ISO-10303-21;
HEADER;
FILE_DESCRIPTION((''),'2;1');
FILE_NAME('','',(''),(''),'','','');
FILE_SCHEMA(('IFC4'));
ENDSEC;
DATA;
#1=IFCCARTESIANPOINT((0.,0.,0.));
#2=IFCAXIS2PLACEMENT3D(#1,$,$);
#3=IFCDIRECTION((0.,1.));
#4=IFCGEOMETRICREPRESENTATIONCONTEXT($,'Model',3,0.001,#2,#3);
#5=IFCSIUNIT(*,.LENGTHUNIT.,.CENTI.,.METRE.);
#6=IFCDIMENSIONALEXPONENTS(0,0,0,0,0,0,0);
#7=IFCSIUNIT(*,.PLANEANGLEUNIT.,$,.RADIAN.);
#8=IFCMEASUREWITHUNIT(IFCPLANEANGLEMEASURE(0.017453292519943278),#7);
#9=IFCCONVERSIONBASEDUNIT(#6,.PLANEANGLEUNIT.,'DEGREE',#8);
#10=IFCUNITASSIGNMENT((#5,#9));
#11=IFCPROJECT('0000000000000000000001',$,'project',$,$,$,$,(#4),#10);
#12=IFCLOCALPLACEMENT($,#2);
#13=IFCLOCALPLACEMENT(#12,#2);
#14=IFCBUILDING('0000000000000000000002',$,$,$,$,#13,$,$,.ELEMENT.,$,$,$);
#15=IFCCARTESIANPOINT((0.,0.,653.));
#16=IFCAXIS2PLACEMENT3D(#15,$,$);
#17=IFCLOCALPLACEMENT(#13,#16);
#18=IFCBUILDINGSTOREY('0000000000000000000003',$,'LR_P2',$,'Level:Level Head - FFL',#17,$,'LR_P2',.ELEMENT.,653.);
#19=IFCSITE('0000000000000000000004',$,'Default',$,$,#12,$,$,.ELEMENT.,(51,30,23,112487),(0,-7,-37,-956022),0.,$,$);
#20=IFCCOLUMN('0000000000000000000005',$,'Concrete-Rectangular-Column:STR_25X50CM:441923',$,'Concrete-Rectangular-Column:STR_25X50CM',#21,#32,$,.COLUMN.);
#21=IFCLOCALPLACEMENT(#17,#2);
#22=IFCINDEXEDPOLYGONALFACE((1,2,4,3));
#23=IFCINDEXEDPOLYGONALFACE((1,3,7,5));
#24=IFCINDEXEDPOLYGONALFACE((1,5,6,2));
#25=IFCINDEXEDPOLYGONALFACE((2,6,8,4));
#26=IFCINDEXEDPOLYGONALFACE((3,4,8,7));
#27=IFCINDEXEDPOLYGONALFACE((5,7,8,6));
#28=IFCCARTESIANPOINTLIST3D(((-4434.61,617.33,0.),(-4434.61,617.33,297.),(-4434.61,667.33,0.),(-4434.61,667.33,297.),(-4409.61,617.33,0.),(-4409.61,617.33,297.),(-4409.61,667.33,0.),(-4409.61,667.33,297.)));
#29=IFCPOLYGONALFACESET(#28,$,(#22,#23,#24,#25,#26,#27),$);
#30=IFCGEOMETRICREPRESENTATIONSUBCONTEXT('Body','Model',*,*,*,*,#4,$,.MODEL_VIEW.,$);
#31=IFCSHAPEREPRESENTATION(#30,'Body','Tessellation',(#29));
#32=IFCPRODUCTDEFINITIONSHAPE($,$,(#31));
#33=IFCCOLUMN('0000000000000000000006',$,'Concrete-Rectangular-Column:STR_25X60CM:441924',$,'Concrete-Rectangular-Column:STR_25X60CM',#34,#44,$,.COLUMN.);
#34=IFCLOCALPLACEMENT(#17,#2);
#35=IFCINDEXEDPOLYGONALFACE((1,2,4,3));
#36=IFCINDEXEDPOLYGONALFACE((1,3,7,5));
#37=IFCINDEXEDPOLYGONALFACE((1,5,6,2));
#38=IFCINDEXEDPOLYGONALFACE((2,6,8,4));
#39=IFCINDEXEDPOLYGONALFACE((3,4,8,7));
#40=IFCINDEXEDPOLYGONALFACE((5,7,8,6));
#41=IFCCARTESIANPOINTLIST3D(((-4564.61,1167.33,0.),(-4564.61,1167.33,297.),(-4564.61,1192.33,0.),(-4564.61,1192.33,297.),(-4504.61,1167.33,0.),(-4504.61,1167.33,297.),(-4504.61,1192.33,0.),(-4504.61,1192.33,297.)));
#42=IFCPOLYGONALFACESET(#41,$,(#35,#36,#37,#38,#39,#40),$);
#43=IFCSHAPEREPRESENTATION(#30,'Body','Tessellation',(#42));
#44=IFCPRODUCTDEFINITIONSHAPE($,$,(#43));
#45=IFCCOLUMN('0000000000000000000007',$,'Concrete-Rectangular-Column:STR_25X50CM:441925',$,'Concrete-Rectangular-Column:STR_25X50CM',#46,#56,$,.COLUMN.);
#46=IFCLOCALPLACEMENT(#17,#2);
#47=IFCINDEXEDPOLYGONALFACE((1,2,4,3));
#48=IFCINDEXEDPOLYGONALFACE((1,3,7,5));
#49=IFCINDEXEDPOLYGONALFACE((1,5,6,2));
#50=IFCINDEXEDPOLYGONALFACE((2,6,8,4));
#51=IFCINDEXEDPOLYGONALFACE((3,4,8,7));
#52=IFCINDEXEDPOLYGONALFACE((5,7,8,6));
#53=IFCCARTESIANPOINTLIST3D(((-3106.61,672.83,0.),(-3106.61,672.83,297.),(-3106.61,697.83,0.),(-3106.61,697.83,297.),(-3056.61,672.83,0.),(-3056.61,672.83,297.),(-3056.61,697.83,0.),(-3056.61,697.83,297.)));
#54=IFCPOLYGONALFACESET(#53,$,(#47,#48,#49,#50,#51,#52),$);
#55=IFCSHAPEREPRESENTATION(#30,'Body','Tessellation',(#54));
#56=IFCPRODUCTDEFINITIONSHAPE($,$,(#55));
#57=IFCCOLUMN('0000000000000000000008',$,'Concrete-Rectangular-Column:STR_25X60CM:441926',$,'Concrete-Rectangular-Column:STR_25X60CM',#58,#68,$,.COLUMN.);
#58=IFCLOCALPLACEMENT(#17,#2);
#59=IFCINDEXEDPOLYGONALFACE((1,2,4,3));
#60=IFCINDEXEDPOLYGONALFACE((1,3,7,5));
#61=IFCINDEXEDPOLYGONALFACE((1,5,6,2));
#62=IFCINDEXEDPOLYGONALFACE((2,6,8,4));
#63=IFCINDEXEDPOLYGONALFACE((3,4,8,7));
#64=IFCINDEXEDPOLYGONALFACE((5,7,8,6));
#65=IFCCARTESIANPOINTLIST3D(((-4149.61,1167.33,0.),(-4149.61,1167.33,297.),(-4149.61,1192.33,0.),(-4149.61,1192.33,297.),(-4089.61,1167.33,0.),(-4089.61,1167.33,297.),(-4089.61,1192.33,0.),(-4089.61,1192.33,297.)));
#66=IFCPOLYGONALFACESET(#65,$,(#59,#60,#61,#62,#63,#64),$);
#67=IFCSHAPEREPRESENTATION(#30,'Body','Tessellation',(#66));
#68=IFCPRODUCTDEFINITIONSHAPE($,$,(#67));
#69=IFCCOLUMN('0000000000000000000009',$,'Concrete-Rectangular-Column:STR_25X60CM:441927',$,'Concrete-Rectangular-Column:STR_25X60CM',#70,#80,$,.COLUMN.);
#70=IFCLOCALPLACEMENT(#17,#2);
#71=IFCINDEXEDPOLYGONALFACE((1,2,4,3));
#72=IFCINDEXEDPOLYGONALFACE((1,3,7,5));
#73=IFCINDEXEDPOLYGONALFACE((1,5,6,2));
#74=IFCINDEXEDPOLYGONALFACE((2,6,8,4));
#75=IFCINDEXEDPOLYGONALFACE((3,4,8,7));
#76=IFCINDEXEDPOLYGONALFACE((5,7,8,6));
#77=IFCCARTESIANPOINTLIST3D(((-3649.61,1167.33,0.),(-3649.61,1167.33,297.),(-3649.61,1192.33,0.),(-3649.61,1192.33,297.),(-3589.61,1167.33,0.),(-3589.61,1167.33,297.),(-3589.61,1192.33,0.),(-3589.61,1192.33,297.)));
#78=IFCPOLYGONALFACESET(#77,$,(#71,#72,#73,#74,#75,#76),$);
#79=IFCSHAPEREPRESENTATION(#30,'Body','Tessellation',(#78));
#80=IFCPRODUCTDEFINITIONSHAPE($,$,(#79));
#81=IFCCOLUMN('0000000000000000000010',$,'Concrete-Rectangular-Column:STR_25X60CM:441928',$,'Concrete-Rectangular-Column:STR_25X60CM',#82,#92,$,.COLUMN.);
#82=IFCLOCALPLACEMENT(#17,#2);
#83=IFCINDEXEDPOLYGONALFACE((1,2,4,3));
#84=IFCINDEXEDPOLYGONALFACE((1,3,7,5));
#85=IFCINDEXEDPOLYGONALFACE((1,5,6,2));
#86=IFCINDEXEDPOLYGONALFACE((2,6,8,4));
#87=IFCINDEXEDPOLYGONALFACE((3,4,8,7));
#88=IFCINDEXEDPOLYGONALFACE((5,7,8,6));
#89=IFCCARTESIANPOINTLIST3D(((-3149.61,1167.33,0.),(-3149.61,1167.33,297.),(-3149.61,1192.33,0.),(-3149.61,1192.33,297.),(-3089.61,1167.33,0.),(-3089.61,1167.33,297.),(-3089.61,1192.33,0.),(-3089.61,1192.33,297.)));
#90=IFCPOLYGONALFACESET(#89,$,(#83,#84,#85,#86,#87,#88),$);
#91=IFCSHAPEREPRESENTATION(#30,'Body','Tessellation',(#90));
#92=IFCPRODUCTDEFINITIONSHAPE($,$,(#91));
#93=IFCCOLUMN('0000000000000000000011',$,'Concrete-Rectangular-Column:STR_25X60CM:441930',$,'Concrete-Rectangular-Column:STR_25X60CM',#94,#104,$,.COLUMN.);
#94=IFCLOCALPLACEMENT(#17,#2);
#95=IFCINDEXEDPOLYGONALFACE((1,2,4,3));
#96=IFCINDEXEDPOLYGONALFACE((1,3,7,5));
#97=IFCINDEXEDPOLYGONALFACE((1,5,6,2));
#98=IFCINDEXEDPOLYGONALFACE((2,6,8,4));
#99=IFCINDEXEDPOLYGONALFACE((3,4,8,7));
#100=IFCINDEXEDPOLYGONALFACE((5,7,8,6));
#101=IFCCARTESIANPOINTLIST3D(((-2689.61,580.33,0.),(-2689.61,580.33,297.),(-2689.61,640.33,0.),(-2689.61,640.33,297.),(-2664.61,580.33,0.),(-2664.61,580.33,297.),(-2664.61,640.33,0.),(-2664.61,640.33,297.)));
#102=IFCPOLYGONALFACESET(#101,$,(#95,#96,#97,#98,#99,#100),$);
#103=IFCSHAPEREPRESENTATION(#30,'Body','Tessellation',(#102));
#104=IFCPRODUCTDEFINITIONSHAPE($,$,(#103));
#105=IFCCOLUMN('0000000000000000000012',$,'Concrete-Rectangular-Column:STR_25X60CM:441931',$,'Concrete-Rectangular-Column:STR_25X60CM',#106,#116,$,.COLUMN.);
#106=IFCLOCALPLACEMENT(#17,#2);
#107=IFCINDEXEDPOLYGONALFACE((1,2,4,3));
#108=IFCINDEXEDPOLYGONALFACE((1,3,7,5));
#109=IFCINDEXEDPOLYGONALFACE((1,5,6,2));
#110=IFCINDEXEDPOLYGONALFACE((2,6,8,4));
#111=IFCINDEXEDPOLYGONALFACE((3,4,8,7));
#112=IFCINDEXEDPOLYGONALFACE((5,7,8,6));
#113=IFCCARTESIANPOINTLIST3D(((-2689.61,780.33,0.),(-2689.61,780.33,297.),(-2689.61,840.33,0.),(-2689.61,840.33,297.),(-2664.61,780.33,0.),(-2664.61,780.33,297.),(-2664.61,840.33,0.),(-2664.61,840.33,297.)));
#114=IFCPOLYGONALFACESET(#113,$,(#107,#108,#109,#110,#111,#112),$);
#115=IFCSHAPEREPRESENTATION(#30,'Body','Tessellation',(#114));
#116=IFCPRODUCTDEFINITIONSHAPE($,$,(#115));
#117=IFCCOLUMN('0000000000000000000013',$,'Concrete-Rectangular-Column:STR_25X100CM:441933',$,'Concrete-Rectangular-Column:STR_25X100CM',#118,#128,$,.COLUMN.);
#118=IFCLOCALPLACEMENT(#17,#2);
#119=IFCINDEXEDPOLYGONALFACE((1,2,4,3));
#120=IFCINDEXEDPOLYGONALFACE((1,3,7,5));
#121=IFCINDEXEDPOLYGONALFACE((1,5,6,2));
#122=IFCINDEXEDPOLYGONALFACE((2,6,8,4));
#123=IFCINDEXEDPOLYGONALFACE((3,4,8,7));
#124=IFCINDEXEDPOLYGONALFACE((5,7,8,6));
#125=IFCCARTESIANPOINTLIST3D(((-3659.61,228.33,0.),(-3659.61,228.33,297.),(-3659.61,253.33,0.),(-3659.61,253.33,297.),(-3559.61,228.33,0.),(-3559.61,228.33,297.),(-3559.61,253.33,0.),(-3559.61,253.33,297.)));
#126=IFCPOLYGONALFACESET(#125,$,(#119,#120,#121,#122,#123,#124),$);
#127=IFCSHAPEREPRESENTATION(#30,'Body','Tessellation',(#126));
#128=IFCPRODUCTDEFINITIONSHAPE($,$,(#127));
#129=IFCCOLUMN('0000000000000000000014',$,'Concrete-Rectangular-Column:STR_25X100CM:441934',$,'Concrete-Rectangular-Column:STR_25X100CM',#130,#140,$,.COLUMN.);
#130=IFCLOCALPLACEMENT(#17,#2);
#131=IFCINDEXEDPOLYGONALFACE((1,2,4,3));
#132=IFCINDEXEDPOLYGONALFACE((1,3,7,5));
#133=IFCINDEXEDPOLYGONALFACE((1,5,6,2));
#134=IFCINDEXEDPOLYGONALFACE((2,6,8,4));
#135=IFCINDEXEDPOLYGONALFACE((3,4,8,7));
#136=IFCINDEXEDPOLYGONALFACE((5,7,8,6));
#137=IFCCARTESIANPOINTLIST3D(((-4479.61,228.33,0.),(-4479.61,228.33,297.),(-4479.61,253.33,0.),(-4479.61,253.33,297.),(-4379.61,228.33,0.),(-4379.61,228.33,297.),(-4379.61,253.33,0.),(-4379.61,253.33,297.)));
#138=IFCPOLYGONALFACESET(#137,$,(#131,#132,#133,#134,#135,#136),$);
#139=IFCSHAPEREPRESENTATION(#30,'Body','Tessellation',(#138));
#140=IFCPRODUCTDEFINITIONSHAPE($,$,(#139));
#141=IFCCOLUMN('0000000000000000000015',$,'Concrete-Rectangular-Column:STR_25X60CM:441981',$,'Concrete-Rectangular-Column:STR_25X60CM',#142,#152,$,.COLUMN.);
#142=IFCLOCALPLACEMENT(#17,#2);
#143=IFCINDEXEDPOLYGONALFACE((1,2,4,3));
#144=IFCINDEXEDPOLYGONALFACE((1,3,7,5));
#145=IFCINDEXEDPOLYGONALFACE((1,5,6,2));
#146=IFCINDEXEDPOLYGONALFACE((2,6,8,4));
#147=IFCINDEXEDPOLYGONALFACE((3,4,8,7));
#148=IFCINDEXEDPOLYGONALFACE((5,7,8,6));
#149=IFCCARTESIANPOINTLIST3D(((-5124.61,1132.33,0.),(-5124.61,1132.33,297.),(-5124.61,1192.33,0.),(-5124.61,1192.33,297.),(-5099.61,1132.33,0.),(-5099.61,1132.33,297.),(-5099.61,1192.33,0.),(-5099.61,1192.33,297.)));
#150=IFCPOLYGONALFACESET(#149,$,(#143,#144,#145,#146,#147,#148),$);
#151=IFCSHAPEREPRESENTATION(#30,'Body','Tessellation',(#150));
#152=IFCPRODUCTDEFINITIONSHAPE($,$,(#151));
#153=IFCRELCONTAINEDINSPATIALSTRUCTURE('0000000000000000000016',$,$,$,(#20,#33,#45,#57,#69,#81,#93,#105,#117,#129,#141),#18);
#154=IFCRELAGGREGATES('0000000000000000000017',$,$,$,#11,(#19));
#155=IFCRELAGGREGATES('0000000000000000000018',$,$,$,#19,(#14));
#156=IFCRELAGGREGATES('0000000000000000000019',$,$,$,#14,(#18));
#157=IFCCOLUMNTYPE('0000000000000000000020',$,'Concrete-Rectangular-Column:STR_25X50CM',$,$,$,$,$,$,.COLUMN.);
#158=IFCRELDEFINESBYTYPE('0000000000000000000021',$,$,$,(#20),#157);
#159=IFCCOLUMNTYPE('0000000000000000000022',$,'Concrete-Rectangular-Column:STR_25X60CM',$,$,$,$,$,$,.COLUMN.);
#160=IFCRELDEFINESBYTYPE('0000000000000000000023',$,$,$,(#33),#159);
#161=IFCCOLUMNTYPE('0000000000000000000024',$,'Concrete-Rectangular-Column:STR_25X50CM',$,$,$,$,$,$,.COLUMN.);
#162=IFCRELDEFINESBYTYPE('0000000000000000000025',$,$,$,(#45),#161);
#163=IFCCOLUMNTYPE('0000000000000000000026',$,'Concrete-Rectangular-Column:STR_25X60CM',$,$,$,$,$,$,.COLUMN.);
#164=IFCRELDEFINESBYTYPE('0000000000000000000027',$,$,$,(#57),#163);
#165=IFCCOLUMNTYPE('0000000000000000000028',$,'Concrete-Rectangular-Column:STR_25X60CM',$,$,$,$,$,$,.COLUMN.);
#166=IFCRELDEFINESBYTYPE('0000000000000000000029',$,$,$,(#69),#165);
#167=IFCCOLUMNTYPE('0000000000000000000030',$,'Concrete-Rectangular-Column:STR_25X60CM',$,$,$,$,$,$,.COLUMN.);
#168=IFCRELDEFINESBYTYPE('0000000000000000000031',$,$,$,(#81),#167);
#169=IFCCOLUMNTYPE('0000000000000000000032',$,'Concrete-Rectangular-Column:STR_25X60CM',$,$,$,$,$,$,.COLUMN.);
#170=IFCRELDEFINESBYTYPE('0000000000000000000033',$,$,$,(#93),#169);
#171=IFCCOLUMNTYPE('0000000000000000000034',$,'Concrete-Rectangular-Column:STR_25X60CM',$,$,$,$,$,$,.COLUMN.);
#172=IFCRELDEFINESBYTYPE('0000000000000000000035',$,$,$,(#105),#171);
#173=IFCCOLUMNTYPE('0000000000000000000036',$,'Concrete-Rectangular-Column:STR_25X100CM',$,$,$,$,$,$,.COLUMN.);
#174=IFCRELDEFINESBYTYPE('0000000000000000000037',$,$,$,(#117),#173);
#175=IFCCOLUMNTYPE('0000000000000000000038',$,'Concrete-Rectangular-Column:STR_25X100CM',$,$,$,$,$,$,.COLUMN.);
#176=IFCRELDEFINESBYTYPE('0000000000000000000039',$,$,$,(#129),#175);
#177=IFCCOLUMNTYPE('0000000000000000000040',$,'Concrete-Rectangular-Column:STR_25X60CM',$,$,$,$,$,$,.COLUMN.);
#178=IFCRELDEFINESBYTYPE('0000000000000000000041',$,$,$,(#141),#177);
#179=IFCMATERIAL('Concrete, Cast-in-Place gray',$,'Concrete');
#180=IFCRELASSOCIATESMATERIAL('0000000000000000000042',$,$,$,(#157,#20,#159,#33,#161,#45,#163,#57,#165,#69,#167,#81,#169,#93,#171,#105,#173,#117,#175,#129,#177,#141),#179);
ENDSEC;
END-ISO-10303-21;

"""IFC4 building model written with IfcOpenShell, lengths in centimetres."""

from ifc_helpers import new_model, entity, si_unit, converted_unit, direction, frame, origin, place, context, subcontext, project, spatial, indexed_curve, outline, extrude, source, transform, mapped, material, type_object, type_shapes, element, save


model = new_model("IFC4")

# Units and contexts
model_context = context("Model", 3, precision=0.001, world=origin(), true_north=direction((0.0, 1.0)))
body_context = subcontext(model_context, "Body", "Model", "MODEL_VIEW")
ifc_project = project(units=[si_unit("LENGTHUNIT", "METRE", prefix="CENTI"), converted_unit("PLANEANGLEUNIT", "DEGREE", entity("IfcPlaneAngleMeasure", 0.017453292519943278), si_unit("PLANEANGLEUNIT", "RADIAN"), dimensions=[0, 0, 0, 0, 0, 0, 0])], contexts=[model_context])

# Site, building, storey
site_placement = place(None, origin())
site = spatial("IfcSite", under=ifc_project, at=site_placement, Name="Default", CompositionType="ELEMENT", RefLatitude=(51, 30, 23, 112487), RefLongitude=(0, -7, -37, -956022), RefElevation=0.0)
building_placement = place(site_placement, origin())
building = spatial("IfcBuilding", under=site, at=building_placement, CompositionType="ELEMENT")
storey_placement = place(building_placement, frame((0.0, 0.0, 653.0)))
storey = spatial("IfcBuildingStorey", under=building, at=storey_placement, Name="LR_P2", ObjectType="Level:Level Head - FFL", LongName="LR_P2", CompositionType="ELEMENT", Elevation=653.0)

# Columns
ifc_material_1 = material(Name="Concrete, Cast-in-Place gray", Category="Concrete")
column_type_1 = type_object("IfcColumnType", Name="Concrete-Rectangular-Column:STR_25X50CM", PredefinedType="COLUMN", material=ifc_material_1)
shared_shape_1 = source(origin(), body_context, "Body", "SweptSolid", [
    extrude(outline(indexed_curve([(-12.5, -25.0), (12.5, -25.0), (12.5, 25.0), (-12.5, 25.0), (-12.5, -25.0)], self_intersect=False)), frame((-4422.11, 642.33, 653.0), z_axis=(0.0, 0.0, 1.0), x_axis=(-1.0, 0.0, 0.0)), (0.0, 0.0, 1.0), 297.0),
])
type_shapes(column_type_1, [shared_shape_1])
column_1_placement = place(storey_placement, frame((0.0, 0.0, -653.0)))
element("IfcColumn", 1, at=column_1_placement, inside=storey, type_object=column_type_1, material=ifc_material_1, Name="Concrete-Rectangular-Column:STR_25X50CM:441923", ObjectType="Concrete-Rectangular-Column:STR_25X50CM", PredefinedType="COLUMN", context=body_context, shape_type="MappedRepresentation", body=[
    mapped(shared_shape_1, transform((0.0, 0.0, 0.0), scale=1.0)),
])
column_type_2 = type_object("IfcColumnType", Name="Concrete-Rectangular-Column:STR_25X60CM", PredefinedType="COLUMN", material=ifc_material_1)
shared_shape_2 = source(origin(), body_context, "Body", "SweptSolid", [
    extrude(outline(indexed_curve([(-12.5, -30.0), (12.5, -30.0), (12.5, 30.0), (-12.5, 30.0), (-12.5, -30.0)], self_intersect=False)), frame((-4534.61, 1179.83, 653.0), z_axis=(0.0, 0.0, 1.0), x_axis=(0.0, -1.0, 0.0)), (0.0, 0.0, 1.0), 297.0),
])
type_shapes(column_type_2, [shared_shape_2])
column_2_placement = place(storey_placement, frame((0.0, 0.0, -653.0)))
element("IfcColumn", 2, at=column_2_placement, inside=storey, type_object=column_type_2, material=ifc_material_1, Name="Concrete-Rectangular-Column:STR_25X60CM:441924", ObjectType="Concrete-Rectangular-Column:STR_25X60CM", PredefinedType="COLUMN", context=body_context, shape_type="MappedRepresentation", body=[
    mapped(shared_shape_2, transform((0.0, 0.0, 0.0), scale=1.0)),
])
column_type_3 = type_object("IfcColumnType", Name="Concrete-Rectangular-Column:STR_25X50CM", PredefinedType="COLUMN", material=ifc_material_1)
shared_shape_3 = source(origin(), body_context, "Body", "SweptSolid", [
    extrude(outline(indexed_curve([(-12.5, -25.0), (12.5, -25.0), (12.5, 25.0), (-12.5, 25.0), (-12.5, -25.0)], self_intersect=False)), frame((-3081.61, 685.33, 653.0), z_axis=(0.0, 0.0, 1.0), x_axis=(0.0, -1.0, 0.0)), (0.0, 0.0, 1.0), 297.0),
])
type_shapes(column_type_3, [shared_shape_3])
column_3_placement = place(storey_placement, frame((0.0, 0.0, -653.0)))
element("IfcColumn", 3, at=column_3_placement, inside=storey, type_object=column_type_3, material=ifc_material_1, Name="Concrete-Rectangular-Column:STR_25X50CM:441925", ObjectType="Concrete-Rectangular-Column:STR_25X50CM", PredefinedType="COLUMN", context=body_context, shape_type="MappedRepresentation", body=[
    mapped(shared_shape_3, transform((0.0, 0.0, 0.0), scale=1.0)),
])
column_type_4 = type_object("IfcColumnType", Name="Concrete-Rectangular-Column:STR_25X60CM", PredefinedType="COLUMN", material=ifc_material_1)
shared_shape_4 = source(origin(), body_context, "Body", "SweptSolid", [
    extrude(outline(indexed_curve([(-12.5, -30.0), (12.5, -30.0), (12.5, 30.0), (-12.5, 30.0), (-12.5, -30.0)], self_intersect=False)), frame((-4119.61, 1179.83, 653.0), z_axis=(0.0, 0.0, 1.0), x_axis=(0.0, -1.0, 0.0)), (0.0, 0.0, 1.0), 297.0),
])
type_shapes(column_type_4, [shared_shape_4])
column_4_placement = place(storey_placement, frame((0.0, 0.0, -653.0)))
element("IfcColumn", 4, at=column_4_placement, inside=storey, type_object=column_type_4, material=ifc_material_1, Name="Concrete-Rectangular-Column:STR_25X60CM:441926", ObjectType="Concrete-Rectangular-Column:STR_25X60CM", PredefinedType="COLUMN", context=body_context, shape_type="MappedRepresentation", body=[
    mapped(shared_shape_4, transform((0.0, 0.0, 0.0), scale=1.0)),
])
column_type_5 = type_object("IfcColumnType", Name="Concrete-Rectangular-Column:STR_25X60CM", PredefinedType="COLUMN", material=ifc_material_1)
shared_shape_5 = source(origin(), body_context, "Body", "SweptSolid", [
    extrude(outline(indexed_curve([(-12.5, -30.0), (12.5, -30.0), (12.5, 30.0), (-12.5, 30.0), (-12.5, -30.0)], self_intersect=False)), frame((-3619.61, 1179.83, 653.0), z_axis=(0.0, 0.0, 1.0), x_axis=(0.0, -1.0, 0.0)), (0.0, 0.0, 1.0), 297.0),
])
type_shapes(column_type_5, [shared_shape_5])
column_5_placement = place(storey_placement, frame((0.0, 0.0, -653.0)))
element("IfcColumn", 5, at=column_5_placement, inside=storey, type_object=column_type_5, material=ifc_material_1, Name="Concrete-Rectangular-Column:STR_25X60CM:441927", ObjectType="Concrete-Rectangular-Column:STR_25X60CM", PredefinedType="COLUMN", context=body_context, shape_type="MappedRepresentation", body=[
    mapped(shared_shape_5, transform((0.0, 0.0, 0.0), scale=1.0)),
])
column_type_6 = type_object("IfcColumnType", Name="Concrete-Rectangular-Column:STR_25X60CM", PredefinedType="COLUMN", material=ifc_material_1)
shared_shape_6 = source(origin(), body_context, "Body", "SweptSolid", [
    extrude(outline(indexed_curve([(-12.5, -30.0), (12.5, -30.0), (12.5, 30.0), (-12.5, 30.0), (-12.5, -30.0)], self_intersect=False)), frame((-3119.61, 1179.83, 653.0), z_axis=(0.0, 0.0, 1.0), x_axis=(0.0, -1.0, 0.0)), (0.0, 0.0, 1.0), 297.0),
])
type_shapes(column_type_6, [shared_shape_6])
column_6_placement = place(storey_placement, frame((0.0, 0.0, -653.0)))
element("IfcColumn", 6, at=column_6_placement, inside=storey, type_object=column_type_6, material=ifc_material_1, Name="Concrete-Rectangular-Column:STR_25X60CM:441928", ObjectType="Concrete-Rectangular-Column:STR_25X60CM", PredefinedType="COLUMN", context=body_context, shape_type="MappedRepresentation", body=[
    mapped(shared_shape_6, transform((0.0, 0.0, 0.0), scale=1.0)),
])
column_type_7 = type_object("IfcColumnType", Name="Concrete-Rectangular-Column:STR_25X60CM", PredefinedType="COLUMN", material=ifc_material_1)
shared_shape_7 = source(origin(), body_context, "Body", "SweptSolid", [
    extrude(outline(indexed_curve([(-12.5, -30.0), (12.5, -30.0), (12.5, 30.0), (-12.5, 30.0), (-12.5, -30.0)], self_intersect=False)), frame((-2677.11, 610.33, 653.0), z_axis=(0.0, 0.0, 1.0), x_axis=(-1.0, 0.0, 0.0)), (0.0, 0.0, 1.0), 297.0),
])
type_shapes(column_type_7, [shared_shape_7])
column_7_placement = place(storey_placement, frame((0.0, 0.0, -653.0)))
element("IfcColumn", 7, at=column_7_placement, inside=storey, type_object=column_type_7, material=ifc_material_1, Name="Concrete-Rectangular-Column:STR_25X60CM:441930", ObjectType="Concrete-Rectangular-Column:STR_25X60CM", PredefinedType="COLUMN", context=body_context, shape_type="MappedRepresentation", body=[
    mapped(shared_shape_7, transform((0.0, 0.0, 0.0), scale=1.0)),
])
column_type_8 = type_object("IfcColumnType", Name="Concrete-Rectangular-Column:STR_25X60CM", PredefinedType="COLUMN", material=ifc_material_1)
shared_shape_8 = source(origin(), body_context, "Body", "SweptSolid", [
    extrude(outline(indexed_curve([(-12.5, -30.0), (12.5, -30.0), (12.5, 30.0), (-12.5, 30.0), (-12.5, -30.0)], self_intersect=False)), frame((-2677.11, 810.33, 653.0), z_axis=(0.0, 0.0, 1.0), x_axis=(-1.0, 0.0, 0.0)), (0.0, 0.0, 1.0), 297.0),
])
type_shapes(column_type_8, [shared_shape_8])
column_8_placement = place(storey_placement, frame((0.0, 0.0, -653.0)))
element("IfcColumn", 8, at=column_8_placement, inside=storey, type_object=column_type_8, material=ifc_material_1, Name="Concrete-Rectangular-Column:STR_25X60CM:441931", ObjectType="Concrete-Rectangular-Column:STR_25X60CM", PredefinedType="COLUMN", context=body_context, shape_type="MappedRepresentation", body=[
    mapped(shared_shape_8, transform((0.0, 0.0, 0.0), scale=1.0)),
])
column_type_9 = type_object("IfcColumnType", Name="Concrete-Rectangular-Column:STR_25X100CM", PredefinedType="COLUMN", material=ifc_material_1)
shared_shape_9 = source(origin(), body_context, "Body", "SweptSolid", [
    extrude(outline(indexed_curve([(-12.5, -50.0), (12.5, -50.0), (12.5, 50.0), (-12.5, 50.0), (-12.5, -50.0)], self_intersect=False)), frame((-3609.61, 240.83, 653.0), z_axis=(0.0, 0.0, 1.0), x_axis=(0.0, -1.0, 0.0)), (0.0, 0.0, 1.0), 297.0),
])
type_shapes(column_type_9, [shared_shape_9])
column_9_placement = place(storey_placement, frame((0.0, 0.0, -653.0)))
element("IfcColumn", 9, at=column_9_placement, inside=storey, type_object=column_type_9, material=ifc_material_1, Name="Concrete-Rectangular-Column:STR_25X100CM:441933", ObjectType="Concrete-Rectangular-Column:STR_25X100CM", PredefinedType="COLUMN", context=body_context, shape_type="MappedRepresentation", body=[
    mapped(shared_shape_9, transform((0.0, 0.0, 0.0), scale=1.0)),
])
column_type_10 = type_object("IfcColumnType", Name="Concrete-Rectangular-Column:STR_25X100CM", PredefinedType="COLUMN", material=ifc_material_1)
shared_shape_10 = source(origin(), body_context, "Body", "SweptSolid", [
    extrude(outline(indexed_curve([(-12.5, -50.0), (12.5, -50.0), (12.5, 50.0), (-12.5, 50.0), (-12.5, -50.0)], self_intersect=False)), frame((-4429.61, 240.83, 653.0), z_axis=(0.0, 0.0, 1.0), x_axis=(0.0, -1.0, 0.0)), (0.0, 0.0, 1.0), 297.0),
])
type_shapes(column_type_10, [shared_shape_10])
column_10_placement = place(storey_placement, frame((0.0, 0.0, -653.0)))
element("IfcColumn", 10, at=column_10_placement, inside=storey, type_object=column_type_10, material=ifc_material_1, Name="Concrete-Rectangular-Column:STR_25X100CM:441934", ObjectType="Concrete-Rectangular-Column:STR_25X100CM", PredefinedType="COLUMN", context=body_context, shape_type="MappedRepresentation", body=[
    mapped(shared_shape_10, transform((0.0, 0.0, 0.0), scale=1.0)),
])
column_type_11 = type_object("IfcColumnType", Name="Concrete-Rectangular-Column:STR_25X60CM", PredefinedType="COLUMN", material=ifc_material_1)
shared_shape_11 = source(origin(), body_context, "Body", "SweptSolid", [
    extrude(outline(indexed_curve([(-12.5, -30.0), (12.5, -30.0), (12.5, 30.0), (-12.5, 30.0), (-12.5, -30.0)], self_intersect=False)), frame((-5112.11, 1162.33, 653.0), z_axis=(0.0, 0.0, 1.0), x_axis=(-1.0, 0.0, 0.0)), (0.0, 0.0, 1.0), 297.0),
])
type_shapes(column_type_11, [shared_shape_11])
column_11_placement = place(storey_placement, frame((0.0, 0.0, -653.0)))
element("IfcColumn", 11, at=column_11_placement, inside=storey, type_object=column_type_11, material=ifc_material_1, Name="Concrete-Rectangular-Column:STR_25X60CM:441981", ObjectType="Concrete-Rectangular-Column:STR_25X60CM", PredefinedType="COLUMN", context=body_context, shape_type="MappedRepresentation", body=[
    mapped(shared_shape_11, transform((0.0, 0.0, 0.0), scale=1.0)),
])

save(model, "model.ifc")
